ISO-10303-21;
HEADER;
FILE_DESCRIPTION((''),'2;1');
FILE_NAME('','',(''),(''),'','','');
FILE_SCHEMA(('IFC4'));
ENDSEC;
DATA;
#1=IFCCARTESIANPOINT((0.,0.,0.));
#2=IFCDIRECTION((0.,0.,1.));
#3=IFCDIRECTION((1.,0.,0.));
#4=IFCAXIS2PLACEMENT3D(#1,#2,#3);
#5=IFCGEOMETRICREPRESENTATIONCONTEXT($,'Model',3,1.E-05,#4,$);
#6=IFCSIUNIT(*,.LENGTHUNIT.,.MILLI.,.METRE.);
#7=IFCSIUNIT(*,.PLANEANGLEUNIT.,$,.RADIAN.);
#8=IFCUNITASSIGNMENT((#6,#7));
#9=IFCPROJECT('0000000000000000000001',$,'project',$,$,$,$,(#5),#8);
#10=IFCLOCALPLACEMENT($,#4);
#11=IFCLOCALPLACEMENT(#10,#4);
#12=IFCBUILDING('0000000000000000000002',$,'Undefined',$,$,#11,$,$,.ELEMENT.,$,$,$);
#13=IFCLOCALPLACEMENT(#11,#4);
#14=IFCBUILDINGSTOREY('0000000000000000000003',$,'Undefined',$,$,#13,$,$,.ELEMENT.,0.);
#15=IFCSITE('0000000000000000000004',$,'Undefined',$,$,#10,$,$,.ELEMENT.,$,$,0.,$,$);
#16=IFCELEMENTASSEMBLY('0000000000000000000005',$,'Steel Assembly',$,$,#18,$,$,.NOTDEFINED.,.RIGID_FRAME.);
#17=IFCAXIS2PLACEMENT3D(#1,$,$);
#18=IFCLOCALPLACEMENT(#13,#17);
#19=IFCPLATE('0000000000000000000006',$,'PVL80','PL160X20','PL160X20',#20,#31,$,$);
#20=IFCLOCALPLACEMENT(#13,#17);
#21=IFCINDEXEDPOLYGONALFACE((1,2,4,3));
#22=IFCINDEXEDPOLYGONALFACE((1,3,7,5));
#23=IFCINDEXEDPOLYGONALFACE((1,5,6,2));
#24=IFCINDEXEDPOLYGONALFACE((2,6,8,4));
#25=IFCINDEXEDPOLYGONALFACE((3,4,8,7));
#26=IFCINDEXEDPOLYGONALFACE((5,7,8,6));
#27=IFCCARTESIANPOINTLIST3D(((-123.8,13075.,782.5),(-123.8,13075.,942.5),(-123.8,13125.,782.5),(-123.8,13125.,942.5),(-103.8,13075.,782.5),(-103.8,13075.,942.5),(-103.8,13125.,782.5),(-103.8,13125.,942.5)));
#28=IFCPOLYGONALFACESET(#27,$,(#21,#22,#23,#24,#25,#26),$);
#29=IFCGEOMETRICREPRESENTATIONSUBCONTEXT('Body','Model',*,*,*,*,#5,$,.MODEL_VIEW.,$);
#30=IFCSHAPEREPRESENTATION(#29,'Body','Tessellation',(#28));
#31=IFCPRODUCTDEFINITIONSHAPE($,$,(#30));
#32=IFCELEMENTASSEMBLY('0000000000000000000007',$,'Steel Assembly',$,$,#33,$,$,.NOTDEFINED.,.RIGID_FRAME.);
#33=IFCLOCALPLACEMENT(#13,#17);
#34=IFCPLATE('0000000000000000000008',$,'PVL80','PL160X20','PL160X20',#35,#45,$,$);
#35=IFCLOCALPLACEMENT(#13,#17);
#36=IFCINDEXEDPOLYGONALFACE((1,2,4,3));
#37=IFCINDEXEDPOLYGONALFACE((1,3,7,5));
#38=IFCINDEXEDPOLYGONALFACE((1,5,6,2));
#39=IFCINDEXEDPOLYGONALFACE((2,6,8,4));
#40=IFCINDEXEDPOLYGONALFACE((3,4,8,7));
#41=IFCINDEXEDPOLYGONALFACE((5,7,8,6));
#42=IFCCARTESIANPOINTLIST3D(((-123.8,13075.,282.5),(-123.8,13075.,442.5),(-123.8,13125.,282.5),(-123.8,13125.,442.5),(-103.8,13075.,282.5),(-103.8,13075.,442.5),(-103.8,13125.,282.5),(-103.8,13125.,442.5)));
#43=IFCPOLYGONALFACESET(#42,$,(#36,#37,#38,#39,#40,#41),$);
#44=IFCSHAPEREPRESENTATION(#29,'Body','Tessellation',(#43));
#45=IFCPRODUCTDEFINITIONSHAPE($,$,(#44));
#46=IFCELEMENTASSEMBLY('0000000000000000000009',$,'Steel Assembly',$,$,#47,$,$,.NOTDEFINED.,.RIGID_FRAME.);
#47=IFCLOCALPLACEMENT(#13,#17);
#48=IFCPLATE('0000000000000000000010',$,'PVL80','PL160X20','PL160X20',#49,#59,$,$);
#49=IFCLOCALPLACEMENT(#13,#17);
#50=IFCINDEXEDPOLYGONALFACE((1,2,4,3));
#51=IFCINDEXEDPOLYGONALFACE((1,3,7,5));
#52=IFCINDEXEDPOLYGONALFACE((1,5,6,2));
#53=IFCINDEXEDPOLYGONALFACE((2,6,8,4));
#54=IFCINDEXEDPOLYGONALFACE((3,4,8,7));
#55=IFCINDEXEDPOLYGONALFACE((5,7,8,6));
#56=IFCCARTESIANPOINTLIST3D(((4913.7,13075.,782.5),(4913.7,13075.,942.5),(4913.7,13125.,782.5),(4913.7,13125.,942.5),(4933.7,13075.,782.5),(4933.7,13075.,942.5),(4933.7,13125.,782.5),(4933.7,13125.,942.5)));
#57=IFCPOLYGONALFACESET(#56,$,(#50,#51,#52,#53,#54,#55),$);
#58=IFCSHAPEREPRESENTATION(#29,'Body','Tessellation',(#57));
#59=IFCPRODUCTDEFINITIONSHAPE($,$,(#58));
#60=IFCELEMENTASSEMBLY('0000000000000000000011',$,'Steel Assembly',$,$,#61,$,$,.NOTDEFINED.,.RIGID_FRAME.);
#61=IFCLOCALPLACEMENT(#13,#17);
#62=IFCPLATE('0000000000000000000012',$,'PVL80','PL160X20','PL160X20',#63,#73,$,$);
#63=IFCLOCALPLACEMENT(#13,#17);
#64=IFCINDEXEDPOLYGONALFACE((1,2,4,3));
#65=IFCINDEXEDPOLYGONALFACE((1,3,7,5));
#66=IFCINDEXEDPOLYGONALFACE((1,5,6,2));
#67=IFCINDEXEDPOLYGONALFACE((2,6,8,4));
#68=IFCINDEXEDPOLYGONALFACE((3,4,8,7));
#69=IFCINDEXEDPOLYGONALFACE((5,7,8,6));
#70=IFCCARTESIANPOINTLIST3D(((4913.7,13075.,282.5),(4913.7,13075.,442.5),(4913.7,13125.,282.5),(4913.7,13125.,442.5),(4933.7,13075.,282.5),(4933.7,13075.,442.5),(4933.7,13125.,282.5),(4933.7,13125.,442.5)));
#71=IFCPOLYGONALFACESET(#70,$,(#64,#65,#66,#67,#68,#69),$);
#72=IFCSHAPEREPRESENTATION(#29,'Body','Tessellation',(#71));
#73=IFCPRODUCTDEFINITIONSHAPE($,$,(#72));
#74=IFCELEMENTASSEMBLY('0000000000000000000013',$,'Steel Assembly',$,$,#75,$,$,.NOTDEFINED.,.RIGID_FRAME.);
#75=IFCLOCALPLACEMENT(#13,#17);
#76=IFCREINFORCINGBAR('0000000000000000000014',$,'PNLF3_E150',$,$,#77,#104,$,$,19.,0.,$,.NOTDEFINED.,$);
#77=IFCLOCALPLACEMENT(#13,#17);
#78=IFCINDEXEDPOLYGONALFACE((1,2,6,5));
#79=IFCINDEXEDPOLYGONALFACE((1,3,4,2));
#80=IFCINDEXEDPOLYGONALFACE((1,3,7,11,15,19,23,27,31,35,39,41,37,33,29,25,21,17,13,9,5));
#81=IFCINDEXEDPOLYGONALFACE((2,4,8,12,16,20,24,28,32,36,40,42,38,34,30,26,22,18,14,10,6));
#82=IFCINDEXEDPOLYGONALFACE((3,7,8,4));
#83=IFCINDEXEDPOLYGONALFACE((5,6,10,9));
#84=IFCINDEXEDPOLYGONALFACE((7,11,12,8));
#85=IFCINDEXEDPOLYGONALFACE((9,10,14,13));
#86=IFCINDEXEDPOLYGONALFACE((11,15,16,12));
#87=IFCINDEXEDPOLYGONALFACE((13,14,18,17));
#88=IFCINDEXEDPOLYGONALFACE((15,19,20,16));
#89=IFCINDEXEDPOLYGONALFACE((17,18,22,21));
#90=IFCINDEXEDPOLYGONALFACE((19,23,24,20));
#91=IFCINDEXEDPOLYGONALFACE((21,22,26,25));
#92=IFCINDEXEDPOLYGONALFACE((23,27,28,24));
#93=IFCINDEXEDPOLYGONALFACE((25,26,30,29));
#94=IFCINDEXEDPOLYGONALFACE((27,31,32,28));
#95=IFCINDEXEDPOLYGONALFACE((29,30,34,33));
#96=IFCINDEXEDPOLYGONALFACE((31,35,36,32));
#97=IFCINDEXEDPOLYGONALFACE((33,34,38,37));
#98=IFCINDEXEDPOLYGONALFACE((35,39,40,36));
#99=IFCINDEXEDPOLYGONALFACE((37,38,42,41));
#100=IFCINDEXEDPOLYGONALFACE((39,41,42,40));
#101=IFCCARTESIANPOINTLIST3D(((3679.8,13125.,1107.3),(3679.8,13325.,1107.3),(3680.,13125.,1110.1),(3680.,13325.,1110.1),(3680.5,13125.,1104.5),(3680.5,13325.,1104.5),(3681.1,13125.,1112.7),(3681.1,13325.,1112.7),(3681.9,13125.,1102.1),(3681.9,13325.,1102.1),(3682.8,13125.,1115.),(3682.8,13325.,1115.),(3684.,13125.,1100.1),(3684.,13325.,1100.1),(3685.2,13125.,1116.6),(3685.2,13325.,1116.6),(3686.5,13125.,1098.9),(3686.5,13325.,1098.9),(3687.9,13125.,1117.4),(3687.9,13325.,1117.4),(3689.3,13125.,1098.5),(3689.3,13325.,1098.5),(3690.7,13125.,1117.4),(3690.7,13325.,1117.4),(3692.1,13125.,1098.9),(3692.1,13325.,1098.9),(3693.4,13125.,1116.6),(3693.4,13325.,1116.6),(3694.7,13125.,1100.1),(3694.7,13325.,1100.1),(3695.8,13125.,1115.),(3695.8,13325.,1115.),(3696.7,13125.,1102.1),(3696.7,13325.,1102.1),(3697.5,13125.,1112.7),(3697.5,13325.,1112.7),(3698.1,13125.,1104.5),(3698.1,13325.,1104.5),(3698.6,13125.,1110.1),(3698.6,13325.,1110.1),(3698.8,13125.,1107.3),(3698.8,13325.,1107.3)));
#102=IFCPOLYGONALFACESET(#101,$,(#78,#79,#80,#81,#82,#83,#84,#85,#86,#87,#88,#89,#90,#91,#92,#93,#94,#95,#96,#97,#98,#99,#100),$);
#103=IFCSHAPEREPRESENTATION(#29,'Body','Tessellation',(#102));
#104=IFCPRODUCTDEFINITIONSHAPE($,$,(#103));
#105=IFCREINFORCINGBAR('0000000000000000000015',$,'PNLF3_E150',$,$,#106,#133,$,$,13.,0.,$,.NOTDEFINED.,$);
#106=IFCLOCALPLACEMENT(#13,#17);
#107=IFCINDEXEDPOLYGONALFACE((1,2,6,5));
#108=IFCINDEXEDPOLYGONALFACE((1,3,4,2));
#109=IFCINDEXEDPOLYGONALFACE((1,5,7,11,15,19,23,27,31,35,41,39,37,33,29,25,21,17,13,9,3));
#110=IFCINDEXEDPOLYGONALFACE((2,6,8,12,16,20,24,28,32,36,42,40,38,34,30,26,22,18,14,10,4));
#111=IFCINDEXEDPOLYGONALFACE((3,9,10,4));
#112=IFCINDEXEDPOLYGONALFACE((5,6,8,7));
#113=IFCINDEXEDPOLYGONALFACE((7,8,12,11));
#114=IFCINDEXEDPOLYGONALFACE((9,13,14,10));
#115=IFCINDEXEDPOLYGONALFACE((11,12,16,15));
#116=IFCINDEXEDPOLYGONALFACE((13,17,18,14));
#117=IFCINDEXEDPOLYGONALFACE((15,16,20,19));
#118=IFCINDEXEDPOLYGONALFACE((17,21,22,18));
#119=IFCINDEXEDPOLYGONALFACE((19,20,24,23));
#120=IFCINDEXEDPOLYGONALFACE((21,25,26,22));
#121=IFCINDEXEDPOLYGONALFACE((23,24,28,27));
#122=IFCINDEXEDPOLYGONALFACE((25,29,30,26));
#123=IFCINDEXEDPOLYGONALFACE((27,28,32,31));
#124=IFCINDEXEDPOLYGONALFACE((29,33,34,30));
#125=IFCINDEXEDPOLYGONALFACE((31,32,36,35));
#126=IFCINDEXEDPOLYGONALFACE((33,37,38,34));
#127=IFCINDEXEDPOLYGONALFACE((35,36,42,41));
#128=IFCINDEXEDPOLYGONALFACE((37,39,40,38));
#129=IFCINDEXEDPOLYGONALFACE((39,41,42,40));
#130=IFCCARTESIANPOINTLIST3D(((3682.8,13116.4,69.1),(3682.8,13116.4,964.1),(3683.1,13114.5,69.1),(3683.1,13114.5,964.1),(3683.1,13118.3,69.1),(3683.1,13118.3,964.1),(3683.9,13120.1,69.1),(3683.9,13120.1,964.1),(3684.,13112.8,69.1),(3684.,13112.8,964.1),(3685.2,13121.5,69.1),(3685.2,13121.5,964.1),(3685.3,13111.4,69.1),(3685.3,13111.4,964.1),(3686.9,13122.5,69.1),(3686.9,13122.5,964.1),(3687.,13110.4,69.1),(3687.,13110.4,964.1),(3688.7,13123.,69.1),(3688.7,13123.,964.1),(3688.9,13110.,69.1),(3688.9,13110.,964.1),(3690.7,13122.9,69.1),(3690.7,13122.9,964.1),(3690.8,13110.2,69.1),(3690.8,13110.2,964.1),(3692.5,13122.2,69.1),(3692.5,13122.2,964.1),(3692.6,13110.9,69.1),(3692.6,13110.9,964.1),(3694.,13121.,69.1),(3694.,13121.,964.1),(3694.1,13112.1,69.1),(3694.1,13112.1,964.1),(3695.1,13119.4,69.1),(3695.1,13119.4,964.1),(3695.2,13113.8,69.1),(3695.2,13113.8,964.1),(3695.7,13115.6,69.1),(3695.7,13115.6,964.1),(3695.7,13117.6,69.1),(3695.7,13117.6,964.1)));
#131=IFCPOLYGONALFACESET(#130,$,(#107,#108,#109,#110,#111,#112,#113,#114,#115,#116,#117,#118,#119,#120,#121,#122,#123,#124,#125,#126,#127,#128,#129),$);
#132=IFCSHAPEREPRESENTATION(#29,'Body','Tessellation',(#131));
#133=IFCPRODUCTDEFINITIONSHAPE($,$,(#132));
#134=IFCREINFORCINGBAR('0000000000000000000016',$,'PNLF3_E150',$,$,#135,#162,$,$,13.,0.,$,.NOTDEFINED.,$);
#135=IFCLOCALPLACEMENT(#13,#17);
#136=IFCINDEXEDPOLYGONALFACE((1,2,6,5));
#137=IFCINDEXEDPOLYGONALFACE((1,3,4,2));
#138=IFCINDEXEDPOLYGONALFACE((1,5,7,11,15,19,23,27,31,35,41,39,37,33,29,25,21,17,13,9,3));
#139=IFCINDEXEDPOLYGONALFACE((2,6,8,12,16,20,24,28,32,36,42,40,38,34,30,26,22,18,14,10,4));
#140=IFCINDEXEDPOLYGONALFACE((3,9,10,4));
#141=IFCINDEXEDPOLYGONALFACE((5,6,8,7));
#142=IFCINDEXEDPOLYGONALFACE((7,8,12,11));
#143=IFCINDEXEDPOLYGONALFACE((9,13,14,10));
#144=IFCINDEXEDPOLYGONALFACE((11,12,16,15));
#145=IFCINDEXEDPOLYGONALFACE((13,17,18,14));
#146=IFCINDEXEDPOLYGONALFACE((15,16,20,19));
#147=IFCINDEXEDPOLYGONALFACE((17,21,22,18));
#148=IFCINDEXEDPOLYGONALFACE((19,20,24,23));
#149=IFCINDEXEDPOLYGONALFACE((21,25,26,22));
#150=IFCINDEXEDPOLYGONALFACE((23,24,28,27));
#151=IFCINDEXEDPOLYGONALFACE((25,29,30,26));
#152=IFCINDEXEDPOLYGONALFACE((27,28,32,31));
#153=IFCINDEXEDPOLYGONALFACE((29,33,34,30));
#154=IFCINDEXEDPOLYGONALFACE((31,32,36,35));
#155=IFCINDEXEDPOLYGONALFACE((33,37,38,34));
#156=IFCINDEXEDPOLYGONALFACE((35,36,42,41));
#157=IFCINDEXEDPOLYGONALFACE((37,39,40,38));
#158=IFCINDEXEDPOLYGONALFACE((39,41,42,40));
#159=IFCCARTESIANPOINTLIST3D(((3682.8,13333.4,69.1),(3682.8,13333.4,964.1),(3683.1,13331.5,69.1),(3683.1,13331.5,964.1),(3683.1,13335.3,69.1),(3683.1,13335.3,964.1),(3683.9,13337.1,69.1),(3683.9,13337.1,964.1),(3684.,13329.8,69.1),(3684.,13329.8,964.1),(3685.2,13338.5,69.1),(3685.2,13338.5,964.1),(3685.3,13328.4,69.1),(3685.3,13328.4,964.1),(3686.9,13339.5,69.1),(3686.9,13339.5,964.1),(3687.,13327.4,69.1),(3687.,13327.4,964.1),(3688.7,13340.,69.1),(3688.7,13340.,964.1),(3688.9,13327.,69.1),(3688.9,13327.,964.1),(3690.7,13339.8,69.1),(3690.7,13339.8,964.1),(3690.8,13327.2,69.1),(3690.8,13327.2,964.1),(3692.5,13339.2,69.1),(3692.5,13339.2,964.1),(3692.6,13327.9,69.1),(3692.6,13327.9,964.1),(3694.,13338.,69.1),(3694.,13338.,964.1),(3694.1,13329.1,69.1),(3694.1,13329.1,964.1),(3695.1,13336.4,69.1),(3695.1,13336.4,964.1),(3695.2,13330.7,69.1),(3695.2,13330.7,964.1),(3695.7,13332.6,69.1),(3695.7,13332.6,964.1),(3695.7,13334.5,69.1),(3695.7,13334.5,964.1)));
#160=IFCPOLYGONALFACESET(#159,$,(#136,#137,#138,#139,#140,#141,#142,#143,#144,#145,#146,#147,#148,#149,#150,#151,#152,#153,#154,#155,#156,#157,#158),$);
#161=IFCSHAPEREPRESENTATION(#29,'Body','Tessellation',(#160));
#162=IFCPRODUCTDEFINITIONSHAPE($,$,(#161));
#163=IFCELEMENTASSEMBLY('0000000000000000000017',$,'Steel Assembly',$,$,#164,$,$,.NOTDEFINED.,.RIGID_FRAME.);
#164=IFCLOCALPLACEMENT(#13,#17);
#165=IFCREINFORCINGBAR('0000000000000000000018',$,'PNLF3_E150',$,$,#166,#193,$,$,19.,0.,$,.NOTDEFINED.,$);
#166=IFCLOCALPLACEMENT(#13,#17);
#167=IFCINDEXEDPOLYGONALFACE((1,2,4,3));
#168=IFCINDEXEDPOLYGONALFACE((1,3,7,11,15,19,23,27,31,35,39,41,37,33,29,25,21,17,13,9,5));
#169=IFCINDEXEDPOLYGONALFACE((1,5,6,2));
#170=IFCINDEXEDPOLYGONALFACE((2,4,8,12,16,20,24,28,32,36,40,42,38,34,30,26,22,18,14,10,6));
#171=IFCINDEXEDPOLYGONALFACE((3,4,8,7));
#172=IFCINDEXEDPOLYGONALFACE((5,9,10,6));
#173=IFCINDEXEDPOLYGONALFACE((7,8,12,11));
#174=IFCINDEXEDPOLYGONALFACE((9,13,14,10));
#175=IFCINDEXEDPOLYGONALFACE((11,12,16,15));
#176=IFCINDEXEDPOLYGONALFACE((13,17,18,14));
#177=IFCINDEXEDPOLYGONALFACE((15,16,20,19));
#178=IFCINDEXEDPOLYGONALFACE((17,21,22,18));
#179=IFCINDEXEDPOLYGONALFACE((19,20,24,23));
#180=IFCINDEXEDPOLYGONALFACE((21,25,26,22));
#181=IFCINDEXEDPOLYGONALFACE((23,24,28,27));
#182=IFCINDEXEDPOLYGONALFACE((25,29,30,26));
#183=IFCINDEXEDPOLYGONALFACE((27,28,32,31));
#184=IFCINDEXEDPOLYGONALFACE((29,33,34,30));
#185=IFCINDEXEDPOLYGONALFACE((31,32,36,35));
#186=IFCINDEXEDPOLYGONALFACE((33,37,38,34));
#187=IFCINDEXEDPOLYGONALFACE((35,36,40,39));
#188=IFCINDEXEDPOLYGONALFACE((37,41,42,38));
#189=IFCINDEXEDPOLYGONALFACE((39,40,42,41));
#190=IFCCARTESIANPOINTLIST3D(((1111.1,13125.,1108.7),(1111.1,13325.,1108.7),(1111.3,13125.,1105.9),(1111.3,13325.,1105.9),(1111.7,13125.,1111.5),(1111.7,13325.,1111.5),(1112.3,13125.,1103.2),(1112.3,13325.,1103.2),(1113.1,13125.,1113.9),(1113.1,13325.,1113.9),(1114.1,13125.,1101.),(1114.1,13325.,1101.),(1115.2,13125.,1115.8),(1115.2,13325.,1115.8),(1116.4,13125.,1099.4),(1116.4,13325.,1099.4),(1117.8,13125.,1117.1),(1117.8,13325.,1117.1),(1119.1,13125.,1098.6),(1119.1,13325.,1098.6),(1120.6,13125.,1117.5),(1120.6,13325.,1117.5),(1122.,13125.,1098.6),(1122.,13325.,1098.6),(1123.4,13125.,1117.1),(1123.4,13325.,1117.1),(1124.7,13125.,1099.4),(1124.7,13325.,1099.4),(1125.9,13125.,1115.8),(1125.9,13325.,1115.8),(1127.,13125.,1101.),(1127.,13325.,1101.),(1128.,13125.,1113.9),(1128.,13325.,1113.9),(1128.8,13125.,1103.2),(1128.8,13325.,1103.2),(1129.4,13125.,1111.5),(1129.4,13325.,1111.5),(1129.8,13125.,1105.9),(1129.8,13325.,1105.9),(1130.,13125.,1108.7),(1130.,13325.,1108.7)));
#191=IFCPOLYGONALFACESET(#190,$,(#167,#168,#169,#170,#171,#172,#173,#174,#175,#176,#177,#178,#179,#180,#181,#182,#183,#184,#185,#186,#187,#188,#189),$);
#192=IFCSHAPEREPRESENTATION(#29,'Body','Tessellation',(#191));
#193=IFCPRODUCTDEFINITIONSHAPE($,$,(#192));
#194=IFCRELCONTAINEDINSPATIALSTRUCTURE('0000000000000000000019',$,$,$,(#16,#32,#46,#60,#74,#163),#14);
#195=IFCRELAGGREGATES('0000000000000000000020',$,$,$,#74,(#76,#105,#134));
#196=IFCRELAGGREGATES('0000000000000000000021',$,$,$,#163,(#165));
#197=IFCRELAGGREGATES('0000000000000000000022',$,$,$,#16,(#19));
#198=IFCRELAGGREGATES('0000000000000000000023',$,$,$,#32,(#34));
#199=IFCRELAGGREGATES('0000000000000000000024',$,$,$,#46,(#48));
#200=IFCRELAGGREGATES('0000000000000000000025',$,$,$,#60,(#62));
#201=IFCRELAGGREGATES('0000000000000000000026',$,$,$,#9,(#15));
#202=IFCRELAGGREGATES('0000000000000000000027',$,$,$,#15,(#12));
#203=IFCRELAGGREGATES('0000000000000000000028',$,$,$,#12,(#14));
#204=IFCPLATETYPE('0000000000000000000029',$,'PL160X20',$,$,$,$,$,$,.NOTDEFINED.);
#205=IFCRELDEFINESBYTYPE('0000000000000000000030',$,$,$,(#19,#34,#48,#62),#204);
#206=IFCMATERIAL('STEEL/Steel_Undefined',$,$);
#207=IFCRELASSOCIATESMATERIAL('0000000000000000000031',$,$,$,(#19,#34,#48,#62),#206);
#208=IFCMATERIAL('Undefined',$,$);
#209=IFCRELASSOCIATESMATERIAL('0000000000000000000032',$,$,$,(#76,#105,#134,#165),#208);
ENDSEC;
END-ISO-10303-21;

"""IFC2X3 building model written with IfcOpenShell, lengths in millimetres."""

from ifc_helpers import new_model, entity, si_unit, frame, origin_with_axes, place, context, subcontext, project, spatial, polyline, outline, extrude, source, transform, mapped, material, type_object, element, aggregate, save


model = new_model("IFC2X3")

# Units and contexts
model_context = context("Model", 3, precision=1e-05, world=origin_with_axes())
body_context = subcontext(model_context, "Body", "Model", "MODEL_VIEW")
ifc_project = project(units=[si_unit("LENGTHUNIT", "METRE", prefix="MILLI"), si_unit("PLANEANGLEUNIT", "RADIAN")], contexts=[model_context])

# Site, building, storey
site_placement = place(None, origin_with_axes())
site = spatial("IfcSite", under=ifc_project, at=site_placement, Name="Undefined", CompositionType="ELEMENT", RefElevation=0.0)
building_placement = place(site_placement, origin_with_axes())
building = spatial("IfcBuilding", under=site, at=building_placement, Name="Undefined", CompositionType="ELEMENT")
storey_placement = place(building_placement, origin_with_axes())
storey = spatial("IfcBuildingStorey", under=building, at=storey_placement, Name="Undefined", CompositionType="ELEMENT", Elevation=0.0)

# Element assemblies, plates
assembly_1_placement = place(storey_placement, origin_with_axes())
assembly_1 = element("IfcElementAssembly", 1, at=assembly_1_placement, inside=storey, Name="Steel Assembly", AssemblyPlace="NOTDEFINED", PredefinedType="RIGID_FRAME")
ifc_material_1 = material(Name="STEEL/Steel_Undefined")
plate_type = type_object("IfcPlateType", Name="PL160X20", PredefinedType="NOTDEFINED")
plate_1_placement = place(assembly_1_placement, frame((-123.8, 13075.0, 862.5), z_axis=(0.0, 0.0, -1.0), x_axis=(0.0, 1.0, 0.0)))
plate_1 = element("IfcPlate", 2, at=plate_1_placement, type_object=plate_type, material=ifc_material_1, Name="PVL80", Description="PL160X20", ObjectType="PL160X20", context=body_context, shape_type="SweptSolid", body=[
    extrude(outline(polyline([(0.0, 0.0), (50.0, 0.0), (50.0, 20.0), (0.0, 20.0), (0.0, 0.0)])), frame((0.0, 0.0, -80.0), z_axis=(0.0, 0.0, 1.0), x_axis=(1.0, 0.0, 0.0)), (0.0, 0.0, 1.0), 160.0),
])
assembly_2_placement = place(storey_placement, origin_with_axes())
assembly_2 = element("IfcElementAssembly", 3, at=assembly_2_placement, inside=storey, Name="Steel Assembly", AssemblyPlace="NOTDEFINED", PredefinedType="RIGID_FRAME")
plate_2_placement = place(assembly_2_placement, frame((-123.8, 13075.0, 362.5), z_axis=(0.0, 0.0, -1.0), x_axis=(0.0, 1.0, 0.0)))
plate_2 = element("IfcPlate", 4, at=plate_2_placement, type_object=plate_type, material=ifc_material_1, Name="PVL80", Description="PL160X20", ObjectType="PL160X20", context=body_context, shape_type="SweptSolid", body=[
    extrude(outline(polyline([(0.0, 0.0), (50.0, 0.0), (50.0, 20.0), (0.0, 20.0), (0.0, 0.0)])), frame((0.0, 0.0, -80.0), z_axis=(0.0, 0.0, 1.0), x_axis=(1.0, 0.0, 0.0)), (0.0, 0.0, 1.0), 160.0),
])
assembly_3_placement = place(storey_placement, origin_with_axes())
assembly_3 = element("IfcElementAssembly", 5, at=assembly_3_placement, inside=storey, Name="Steel Assembly", AssemblyPlace="NOTDEFINED", PredefinedType="RIGID_FRAME")
plate_3_placement = place(assembly_3_placement, frame((4933.7, 13125.0, 862.5), z_axis=(0.0, 0.0, -1.0), x_axis=(0.0, -1.0, 0.0)))
plate_3 = element("IfcPlate", 6, at=plate_3_placement, type_object=plate_type, material=ifc_material_1, Name="PVL80", Description="PL160X20", ObjectType="PL160X20", context=body_context, shape_type="SweptSolid", body=[
    extrude(outline(polyline([(0.0, 0.0), (50.0, 0.0), (50.0, 20.0), (0.0, 20.0), (0.0, 0.0)])), frame((0.0, 0.0, -80.0), z_axis=(0.0, 0.0, 1.0), x_axis=(1.0, 0.0, 0.0)), (0.0, 0.0, 1.0), 160.0),
])
assembly_4_placement = place(storey_placement, origin_with_axes())
assembly_4 = element("IfcElementAssembly", 7, at=assembly_4_placement, inside=storey, Name="Steel Assembly", AssemblyPlace="NOTDEFINED", PredefinedType="RIGID_FRAME")
plate_4_placement = place(assembly_4_placement, frame((4933.7, 13125.0, 362.5), z_axis=(0.0, 0.0, -1.0), x_axis=(0.0, -1.0, 0.0)))
plate_4 = element("IfcPlate", 8, at=plate_4_placement, type_object=plate_type, material=ifc_material_1, Name="PVL80", Description="PL160X20", ObjectType="PL160X20", context=body_context, shape_type="SweptSolid", body=[
    extrude(outline(polyline([(0.0, 0.0), (50.0, 0.0), (50.0, 20.0), (0.0, 20.0), (0.0, 0.0)])), frame((0.0, 0.0, -80.0), z_axis=(0.0, 0.0, 1.0), x_axis=(1.0, 0.0, 0.0)), (0.0, 0.0, 1.0), 160.0),
])

# Element assemblies, reinforcing bars
assembly_5_placement = place(storey_placement, origin_with_axes())
assembly_5 = element("IfcElementAssembly", 9, at=assembly_5_placement, inside=storey, Name="Steel Assembly", AssemblyPlace="NOTDEFINED", PredefinedType="RIGID_FRAME")
ifc_material_2 = material(Name="Undefined")
shared_shape_1 = source(origin_with_axes(), body_context, "Body", "AdvancedSweptSolid", [
    entity("IfcSweptDiskSolid", entity("IfcTrimmedCurve", entity("IfcLine", entity("IfcCartesianPoint", [0.0, 0.0, 0.0]), entity("IfcVector", entity("IfcDirection", [1.0, 0.0, 0.0]), 1.0)), [entity("IfcParameterValue", 0.0)], [entity("IfcParameterValue", 199.989627)], True, "PARAMETER"), 9.5, None, 0.0, 200.0),
])
reinforcing_bar_1_placement = place(assembly_5_placement, frame((3689.3, 13125.0, 1108.0), z_axis=(0.0, 0.0, -1.0), x_axis=(0.0, 1.0, 0.0)))
reinforcing_bar_1 = element("IfcReinforcingBar", 10, at=reinforcing_bar_1_placement, material=ifc_material_2, Name="PNLF3_E150", BarRole="NOTDEFINED", CrossSectionArea=0.0, NominalDiameter=19.0, context=body_context, shape_type="MappedRepresentation", body=[
    mapped(shared_shape_1, transform((0.0, 0.0, 0.0))),
])
shared_shape_2 = source(origin_with_axes(), body_context, "Body", "AdvancedSweptSolid", [
    entity("IfcSweptDiskSolid", entity("IfcTrimmedCurve", entity("IfcLine", entity("IfcCartesianPoint", [0.0, 0.0, 0.0]), entity("IfcVector", entity("IfcDirection", [1.0, 0.0, 0.0]), 1.0)), [entity("IfcParameterValue", 0.0)], [entity("IfcParameterValue", 895.0)], True, "PARAMETER"), 6.5, None, 0.0, 895.0),
])
reinforcing_bar_2_placement = place(assembly_5_placement, frame((3689.3, 13116.5, 964.1), z_axis=(-0.999922, -0.012456, 0.0), x_axis=(0.0, 0.0, -1.0)))
reinforcing_bar_2 = element("IfcReinforcingBar", 11, at=reinforcing_bar_2_placement, material=ifc_material_2, Name="PNLF3_E150", BarRole="NOTDEFINED", CrossSectionArea=0.0, NominalDiameter=13.0, context=body_context, shape_type="MappedRepresentation", body=[
    mapped(shared_shape_2, transform((0.0, 0.0, 0.0))),
])
shared_shape_3 = source(origin_with_axes(), body_context, "Body", "AdvancedSweptSolid", [
    entity("IfcSweptDiskSolid", entity("IfcTrimmedCurve", entity("IfcLine", entity("IfcCartesianPoint", [0.0, 0.0, 0.0]), entity("IfcVector", entity("IfcDirection", [1.0, 0.0, 0.0]), 1.0)), [entity("IfcParameterValue", 0.0)], [entity("IfcParameterValue", 895.0)], True, "PARAMETER"), 6.5, None, 0.0, 895.0),
])
reinforcing_bar_3_placement = place(assembly_5_placement, frame((3689.3, 13333.5, 964.1), z_axis=(-0.999922, -0.012456, 0.0), x_axis=(0.0, 0.0, -1.0)))
reinforcing_bar_3 = element("IfcReinforcingBar", 12, at=reinforcing_bar_3_placement, material=ifc_material_2, Name="PNLF3_E150", BarRole="NOTDEFINED", CrossSectionArea=0.0, NominalDiameter=13.0, context=body_context, shape_type="MappedRepresentation", body=[
    mapped(shared_shape_3, transform((0.0, 0.0, 0.0))),
])
aggregate(assembly_5, [reinforcing_bar_1, reinforcing_bar_2, reinforcing_bar_3])
assembly_6_placement = place(storey_placement, origin_with_axes())
assembly_6 = element("IfcElementAssembly", 13, at=assembly_6_placement, inside=storey, Name="Steel Assembly", AssemblyPlace="NOTDEFINED", PredefinedType="RIGID_FRAME")
shared_shape_4 = source(origin_with_axes(), body_context, "Body", "AdvancedSweptSolid", [
    entity("IfcSweptDiskSolid", entity("IfcTrimmedCurve", entity("IfcLine", entity("IfcCartesianPoint", [0.0, 0.0, 0.0]), entity("IfcVector", entity("IfcDirection", [1.0, 0.0, 0.0]), 1.0)), [entity("IfcParameterValue", 0.0)], [entity("IfcParameterValue", 199.989627)], True, "PARAMETER"), 9.5, None, 0.0, 200.0),
])
reinforcing_bar_4_placement = place(assembly_6_placement, frame((1120.6, 13325.0, 1108.0), z_axis=(0.0, 0.0, 1.0), x_axis=(0.0, -1.0, 0.0)))
reinforcing_bar_4 = element("IfcReinforcingBar", 14, at=reinforcing_bar_4_placement, material=ifc_material_2, Name="PNLF3_E150", BarRole="NOTDEFINED", CrossSectionArea=0.0, NominalDiameter=19.0, context=body_context, shape_type="MappedRepresentation", body=[
    mapped(shared_shape_4, transform((0.0, 0.0, 0.0))),
])
aggregate(assembly_6, [reinforcing_bar_4])

aggregate(assembly_1, [plate_1])
aggregate(assembly_2, [plate_2])
aggregate(assembly_3, [plate_3])
aggregate(assembly_4, [plate_4])

save(model, "model.ifc")
